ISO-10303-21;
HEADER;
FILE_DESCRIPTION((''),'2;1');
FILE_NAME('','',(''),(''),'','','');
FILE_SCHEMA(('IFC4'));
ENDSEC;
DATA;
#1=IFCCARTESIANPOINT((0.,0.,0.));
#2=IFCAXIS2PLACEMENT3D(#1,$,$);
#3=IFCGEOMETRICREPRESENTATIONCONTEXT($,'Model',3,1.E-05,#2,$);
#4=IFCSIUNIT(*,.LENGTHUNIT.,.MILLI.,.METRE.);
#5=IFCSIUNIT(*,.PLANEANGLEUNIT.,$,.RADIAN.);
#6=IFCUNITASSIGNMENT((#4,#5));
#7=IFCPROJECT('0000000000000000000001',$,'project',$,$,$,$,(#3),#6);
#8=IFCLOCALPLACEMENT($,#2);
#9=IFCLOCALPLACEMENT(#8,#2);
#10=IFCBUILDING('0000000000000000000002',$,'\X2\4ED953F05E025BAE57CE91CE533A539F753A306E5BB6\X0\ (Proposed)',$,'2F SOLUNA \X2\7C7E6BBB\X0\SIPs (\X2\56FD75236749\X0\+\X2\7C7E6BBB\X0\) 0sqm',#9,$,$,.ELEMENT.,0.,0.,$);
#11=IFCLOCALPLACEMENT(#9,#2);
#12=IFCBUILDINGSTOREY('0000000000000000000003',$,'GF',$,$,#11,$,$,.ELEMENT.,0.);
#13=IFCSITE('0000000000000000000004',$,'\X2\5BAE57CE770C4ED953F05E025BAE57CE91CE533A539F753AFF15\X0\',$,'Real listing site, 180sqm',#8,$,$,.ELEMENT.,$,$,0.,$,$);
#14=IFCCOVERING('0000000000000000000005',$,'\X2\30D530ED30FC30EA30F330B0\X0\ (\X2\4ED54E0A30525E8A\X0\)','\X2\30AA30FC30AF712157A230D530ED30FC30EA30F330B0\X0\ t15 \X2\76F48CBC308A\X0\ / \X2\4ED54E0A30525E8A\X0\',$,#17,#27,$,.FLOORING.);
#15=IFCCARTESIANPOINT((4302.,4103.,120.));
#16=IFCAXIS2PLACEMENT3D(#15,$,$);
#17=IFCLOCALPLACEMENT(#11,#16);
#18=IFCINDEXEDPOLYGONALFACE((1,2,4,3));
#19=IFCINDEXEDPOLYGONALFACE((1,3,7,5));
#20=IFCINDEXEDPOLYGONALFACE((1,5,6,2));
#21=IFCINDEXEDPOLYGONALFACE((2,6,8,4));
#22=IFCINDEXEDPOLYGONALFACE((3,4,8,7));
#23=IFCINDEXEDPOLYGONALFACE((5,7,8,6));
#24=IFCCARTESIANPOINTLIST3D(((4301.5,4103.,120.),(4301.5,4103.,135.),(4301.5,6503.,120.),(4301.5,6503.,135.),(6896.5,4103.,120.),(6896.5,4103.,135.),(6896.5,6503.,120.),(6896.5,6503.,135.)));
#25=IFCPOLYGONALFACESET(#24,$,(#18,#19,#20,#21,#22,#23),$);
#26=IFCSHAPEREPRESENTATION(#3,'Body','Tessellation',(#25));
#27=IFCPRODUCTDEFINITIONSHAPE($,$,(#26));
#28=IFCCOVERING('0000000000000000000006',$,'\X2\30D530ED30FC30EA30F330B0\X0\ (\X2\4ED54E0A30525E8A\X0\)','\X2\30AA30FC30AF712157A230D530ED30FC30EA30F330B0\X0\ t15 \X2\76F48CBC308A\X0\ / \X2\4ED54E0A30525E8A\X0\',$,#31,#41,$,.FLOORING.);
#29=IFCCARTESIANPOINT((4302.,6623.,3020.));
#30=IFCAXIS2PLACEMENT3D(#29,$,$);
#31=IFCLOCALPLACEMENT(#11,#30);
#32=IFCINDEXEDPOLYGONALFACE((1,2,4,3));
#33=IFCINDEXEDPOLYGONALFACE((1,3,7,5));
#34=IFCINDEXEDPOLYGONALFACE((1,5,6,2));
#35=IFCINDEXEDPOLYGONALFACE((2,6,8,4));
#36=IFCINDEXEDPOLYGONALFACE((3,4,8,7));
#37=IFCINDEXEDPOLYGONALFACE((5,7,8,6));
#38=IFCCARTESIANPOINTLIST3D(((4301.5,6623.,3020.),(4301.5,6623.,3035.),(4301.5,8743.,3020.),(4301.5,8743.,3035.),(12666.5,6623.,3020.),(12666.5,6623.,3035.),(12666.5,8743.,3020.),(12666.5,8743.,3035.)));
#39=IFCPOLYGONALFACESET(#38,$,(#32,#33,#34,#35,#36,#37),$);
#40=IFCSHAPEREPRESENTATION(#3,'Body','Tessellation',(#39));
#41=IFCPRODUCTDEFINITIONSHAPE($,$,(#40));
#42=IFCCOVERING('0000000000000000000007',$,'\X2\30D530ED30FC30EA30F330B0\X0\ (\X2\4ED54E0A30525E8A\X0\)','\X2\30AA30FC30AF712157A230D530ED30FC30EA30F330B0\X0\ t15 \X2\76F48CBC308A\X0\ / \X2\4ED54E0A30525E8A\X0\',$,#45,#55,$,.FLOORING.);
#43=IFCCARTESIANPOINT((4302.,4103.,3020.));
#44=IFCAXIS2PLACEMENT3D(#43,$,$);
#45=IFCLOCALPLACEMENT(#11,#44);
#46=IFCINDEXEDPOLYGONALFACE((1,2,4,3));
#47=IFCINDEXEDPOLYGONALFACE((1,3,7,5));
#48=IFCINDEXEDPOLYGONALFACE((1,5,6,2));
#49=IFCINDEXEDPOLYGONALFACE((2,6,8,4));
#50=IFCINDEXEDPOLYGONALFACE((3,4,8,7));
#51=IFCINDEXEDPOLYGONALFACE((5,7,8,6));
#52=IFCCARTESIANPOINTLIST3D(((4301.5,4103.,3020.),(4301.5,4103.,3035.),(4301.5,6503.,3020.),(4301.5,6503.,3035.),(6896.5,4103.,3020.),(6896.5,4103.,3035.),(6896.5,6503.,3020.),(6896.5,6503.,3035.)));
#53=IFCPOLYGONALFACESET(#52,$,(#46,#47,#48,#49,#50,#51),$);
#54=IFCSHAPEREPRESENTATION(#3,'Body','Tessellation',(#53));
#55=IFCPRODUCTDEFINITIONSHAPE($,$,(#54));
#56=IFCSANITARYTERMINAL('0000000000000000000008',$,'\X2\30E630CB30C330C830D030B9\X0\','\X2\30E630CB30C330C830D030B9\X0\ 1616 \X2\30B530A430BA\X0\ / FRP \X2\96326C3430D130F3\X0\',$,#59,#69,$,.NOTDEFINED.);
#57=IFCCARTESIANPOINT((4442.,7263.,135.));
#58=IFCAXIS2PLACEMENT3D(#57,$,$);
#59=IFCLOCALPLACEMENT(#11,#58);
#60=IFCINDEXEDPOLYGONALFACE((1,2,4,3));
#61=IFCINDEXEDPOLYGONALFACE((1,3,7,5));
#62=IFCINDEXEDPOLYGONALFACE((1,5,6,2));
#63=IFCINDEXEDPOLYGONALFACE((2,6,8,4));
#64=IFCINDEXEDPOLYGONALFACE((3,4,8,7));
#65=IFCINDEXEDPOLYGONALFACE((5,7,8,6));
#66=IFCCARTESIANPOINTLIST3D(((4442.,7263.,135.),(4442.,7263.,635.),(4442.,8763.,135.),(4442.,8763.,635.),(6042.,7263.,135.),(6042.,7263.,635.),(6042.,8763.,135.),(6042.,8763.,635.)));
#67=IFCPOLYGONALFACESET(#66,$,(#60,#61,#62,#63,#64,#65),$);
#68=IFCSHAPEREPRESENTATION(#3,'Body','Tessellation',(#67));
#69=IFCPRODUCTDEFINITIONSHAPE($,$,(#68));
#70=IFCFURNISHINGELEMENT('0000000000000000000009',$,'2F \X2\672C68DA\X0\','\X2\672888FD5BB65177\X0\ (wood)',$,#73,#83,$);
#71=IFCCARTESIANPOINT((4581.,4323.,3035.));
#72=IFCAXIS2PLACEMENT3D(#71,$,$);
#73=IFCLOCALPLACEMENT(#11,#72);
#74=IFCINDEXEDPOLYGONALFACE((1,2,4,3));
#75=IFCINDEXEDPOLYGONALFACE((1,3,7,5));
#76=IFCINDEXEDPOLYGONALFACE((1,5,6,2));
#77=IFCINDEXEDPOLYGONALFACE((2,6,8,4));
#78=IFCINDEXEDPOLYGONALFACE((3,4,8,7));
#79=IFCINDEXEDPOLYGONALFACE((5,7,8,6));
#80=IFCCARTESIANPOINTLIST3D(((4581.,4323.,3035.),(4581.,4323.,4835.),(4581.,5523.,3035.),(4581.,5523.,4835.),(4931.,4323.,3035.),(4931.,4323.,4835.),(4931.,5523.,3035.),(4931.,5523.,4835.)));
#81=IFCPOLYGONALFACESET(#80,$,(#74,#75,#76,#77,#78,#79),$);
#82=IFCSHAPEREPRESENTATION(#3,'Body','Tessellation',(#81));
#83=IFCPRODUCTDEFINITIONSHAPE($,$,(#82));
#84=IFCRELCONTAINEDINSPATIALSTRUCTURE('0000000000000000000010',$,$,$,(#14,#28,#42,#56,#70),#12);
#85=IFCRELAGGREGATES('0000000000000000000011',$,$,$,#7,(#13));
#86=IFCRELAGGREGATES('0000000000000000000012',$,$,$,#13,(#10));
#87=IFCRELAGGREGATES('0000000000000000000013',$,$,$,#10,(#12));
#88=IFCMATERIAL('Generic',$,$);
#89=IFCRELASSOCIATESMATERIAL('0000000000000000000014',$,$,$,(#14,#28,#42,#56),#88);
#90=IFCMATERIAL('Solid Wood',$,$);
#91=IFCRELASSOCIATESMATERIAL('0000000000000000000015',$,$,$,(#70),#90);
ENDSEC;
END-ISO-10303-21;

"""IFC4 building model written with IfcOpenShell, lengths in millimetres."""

from ifc_helpers import new_model, si_unit, frame, frame_2d, origin, place, context, project, spatial, rectangle, extrude, material, element, save


model = new_model("IFC4")

# Units and contexts
model_context = context("Model", 3, precision=1e-05, world=origin())
ifc_project = project(units=[si_unit("LENGTHUNIT", "METRE", prefix="MILLI"), si_unit("PLANEANGLEUNIT", "RADIAN")], contexts=[model_context])

# Site, building, storey
site_placement = place(None, origin())
site = spatial("IfcSite", under=ifc_project, at=site_placement, Name="宮城県仙台市宮城野区原町５", ObjectType="Real listing site, 180sqm", CompositionType="ELEMENT", RefElevation=0.0)
building_placement = place(site_placement, origin())
building = spatial("IfcBuilding", under=site, at=building_placement, Name="仙台市宮城野区原町の家 (Proposed)", ObjectType="2F SOLUNA 籾殻SIPs (国産杉+籾殻) 0sqm", CompositionType="ELEMENT", ElevationOfRefHeight=0.0, ElevationOfTerrain=0.0)
storey_placement = place(building_placement, origin())
storey = spatial("IfcBuildingStorey", under=building, at=storey_placement, Name="GF", CompositionType="ELEMENT", Elevation=0.0)

# Shared definitions
ifc_material_1 = material(Name="Solid Wood")

# Coverings
ifc_material_2 = material(Name="Generic")
covering_1_placement = place(storey_placement, frame((4302.0, 4103.0, 120.0)))
element("IfcCovering", 1, at=covering_1_placement, inside=storey, material=ifc_material_2, Name="フローリング (仕上げ床)", Description="オーク無垢フローリング t15 直貼り / 仕上げ床", PredefinedType="FLOORING", context=model_context, shape_type="SweptSolid", body=[
    extrude(rectangle(XDim=2595.0, YDim=2400.0, at=frame_2d((1297.0, 1200.0))), frame((4302.0, 4103.0, 120.0)), (0.0, 0.0, 1.0), 15.0),
])
covering_2_placement = place(storey_placement, frame((4302.0, 6623.0, 3020.0)))
element("IfcCovering", 2, at=covering_2_placement, inside=storey, material=ifc_material_2, Name="フローリング (仕上げ床)", Description="オーク無垢フローリング t15 直貼り / 仕上げ床", PredefinedType="FLOORING", context=model_context, shape_type="SweptSolid", body=[
    extrude(rectangle(XDim=8365.0, YDim=2120.0, at=frame_2d((4182.0, 1060.0))), frame((4302.0, 6623.0, 3020.0)), (0.0, 0.0, 1.0), 15.0),
])
covering_3_placement = place(storey_placement, frame((4302.0, 4103.0, 3020.0)))
element("IfcCovering", 3, at=covering_3_placement, inside=storey, material=ifc_material_2, Name="フローリング (仕上げ床)", Description="オーク無垢フローリング t15 直貼り / 仕上げ床", PredefinedType="FLOORING", context=model_context, shape_type="SweptSolid", body=[
    extrude(rectangle(XDim=2595.0, YDim=2400.0, at=frame_2d((1297.0, 1200.0))), frame((4302.0, 4103.0, 3020.0)), (0.0, 0.0, 1.0), 15.0),
])

# Sanitary terminal
sanitary_terminal_placement = place(storey_placement, frame((4442.0, 7263.0, 135.0)))
element("IfcSanitaryTerminal", 4, at=sanitary_terminal_placement, inside=storey, material=ifc_material_2, Name="ユニットバス", Description="ユニットバス 1616 サイズ / FRP 防水パン", PredefinedType="NOTDEFINED", context=model_context, shape_type="SweptSolid", body=[
    extrude(rectangle(XDim=1600.0, YDim=1500.0, at=frame_2d((800.0, 750.0))), frame((4442.0, 7263.0, 135.0)), (0.0, 0.0, 1.0), 500.0),
])

# Furnishing element
furnishing_placement = place(storey_placement, frame((4581.0, 4323.0, 3035.0)))
element("IfcFurnishingElement", 5, at=furnishing_placement, inside=storey, material=ifc_material_1, Name="2F 本棚", Description="木製家具 (wood)", context=model_context, shape_type="SweptSolid", body=[
    extrude(rectangle(XDim=350.0, YDim=1200.0, at=frame_2d((175.0, 600.0))), frame((4581.0, 4323.0, 3035.0)), (0.0, 0.0, 1.0), 1800.0),
])

save(model, "model.ifc")
